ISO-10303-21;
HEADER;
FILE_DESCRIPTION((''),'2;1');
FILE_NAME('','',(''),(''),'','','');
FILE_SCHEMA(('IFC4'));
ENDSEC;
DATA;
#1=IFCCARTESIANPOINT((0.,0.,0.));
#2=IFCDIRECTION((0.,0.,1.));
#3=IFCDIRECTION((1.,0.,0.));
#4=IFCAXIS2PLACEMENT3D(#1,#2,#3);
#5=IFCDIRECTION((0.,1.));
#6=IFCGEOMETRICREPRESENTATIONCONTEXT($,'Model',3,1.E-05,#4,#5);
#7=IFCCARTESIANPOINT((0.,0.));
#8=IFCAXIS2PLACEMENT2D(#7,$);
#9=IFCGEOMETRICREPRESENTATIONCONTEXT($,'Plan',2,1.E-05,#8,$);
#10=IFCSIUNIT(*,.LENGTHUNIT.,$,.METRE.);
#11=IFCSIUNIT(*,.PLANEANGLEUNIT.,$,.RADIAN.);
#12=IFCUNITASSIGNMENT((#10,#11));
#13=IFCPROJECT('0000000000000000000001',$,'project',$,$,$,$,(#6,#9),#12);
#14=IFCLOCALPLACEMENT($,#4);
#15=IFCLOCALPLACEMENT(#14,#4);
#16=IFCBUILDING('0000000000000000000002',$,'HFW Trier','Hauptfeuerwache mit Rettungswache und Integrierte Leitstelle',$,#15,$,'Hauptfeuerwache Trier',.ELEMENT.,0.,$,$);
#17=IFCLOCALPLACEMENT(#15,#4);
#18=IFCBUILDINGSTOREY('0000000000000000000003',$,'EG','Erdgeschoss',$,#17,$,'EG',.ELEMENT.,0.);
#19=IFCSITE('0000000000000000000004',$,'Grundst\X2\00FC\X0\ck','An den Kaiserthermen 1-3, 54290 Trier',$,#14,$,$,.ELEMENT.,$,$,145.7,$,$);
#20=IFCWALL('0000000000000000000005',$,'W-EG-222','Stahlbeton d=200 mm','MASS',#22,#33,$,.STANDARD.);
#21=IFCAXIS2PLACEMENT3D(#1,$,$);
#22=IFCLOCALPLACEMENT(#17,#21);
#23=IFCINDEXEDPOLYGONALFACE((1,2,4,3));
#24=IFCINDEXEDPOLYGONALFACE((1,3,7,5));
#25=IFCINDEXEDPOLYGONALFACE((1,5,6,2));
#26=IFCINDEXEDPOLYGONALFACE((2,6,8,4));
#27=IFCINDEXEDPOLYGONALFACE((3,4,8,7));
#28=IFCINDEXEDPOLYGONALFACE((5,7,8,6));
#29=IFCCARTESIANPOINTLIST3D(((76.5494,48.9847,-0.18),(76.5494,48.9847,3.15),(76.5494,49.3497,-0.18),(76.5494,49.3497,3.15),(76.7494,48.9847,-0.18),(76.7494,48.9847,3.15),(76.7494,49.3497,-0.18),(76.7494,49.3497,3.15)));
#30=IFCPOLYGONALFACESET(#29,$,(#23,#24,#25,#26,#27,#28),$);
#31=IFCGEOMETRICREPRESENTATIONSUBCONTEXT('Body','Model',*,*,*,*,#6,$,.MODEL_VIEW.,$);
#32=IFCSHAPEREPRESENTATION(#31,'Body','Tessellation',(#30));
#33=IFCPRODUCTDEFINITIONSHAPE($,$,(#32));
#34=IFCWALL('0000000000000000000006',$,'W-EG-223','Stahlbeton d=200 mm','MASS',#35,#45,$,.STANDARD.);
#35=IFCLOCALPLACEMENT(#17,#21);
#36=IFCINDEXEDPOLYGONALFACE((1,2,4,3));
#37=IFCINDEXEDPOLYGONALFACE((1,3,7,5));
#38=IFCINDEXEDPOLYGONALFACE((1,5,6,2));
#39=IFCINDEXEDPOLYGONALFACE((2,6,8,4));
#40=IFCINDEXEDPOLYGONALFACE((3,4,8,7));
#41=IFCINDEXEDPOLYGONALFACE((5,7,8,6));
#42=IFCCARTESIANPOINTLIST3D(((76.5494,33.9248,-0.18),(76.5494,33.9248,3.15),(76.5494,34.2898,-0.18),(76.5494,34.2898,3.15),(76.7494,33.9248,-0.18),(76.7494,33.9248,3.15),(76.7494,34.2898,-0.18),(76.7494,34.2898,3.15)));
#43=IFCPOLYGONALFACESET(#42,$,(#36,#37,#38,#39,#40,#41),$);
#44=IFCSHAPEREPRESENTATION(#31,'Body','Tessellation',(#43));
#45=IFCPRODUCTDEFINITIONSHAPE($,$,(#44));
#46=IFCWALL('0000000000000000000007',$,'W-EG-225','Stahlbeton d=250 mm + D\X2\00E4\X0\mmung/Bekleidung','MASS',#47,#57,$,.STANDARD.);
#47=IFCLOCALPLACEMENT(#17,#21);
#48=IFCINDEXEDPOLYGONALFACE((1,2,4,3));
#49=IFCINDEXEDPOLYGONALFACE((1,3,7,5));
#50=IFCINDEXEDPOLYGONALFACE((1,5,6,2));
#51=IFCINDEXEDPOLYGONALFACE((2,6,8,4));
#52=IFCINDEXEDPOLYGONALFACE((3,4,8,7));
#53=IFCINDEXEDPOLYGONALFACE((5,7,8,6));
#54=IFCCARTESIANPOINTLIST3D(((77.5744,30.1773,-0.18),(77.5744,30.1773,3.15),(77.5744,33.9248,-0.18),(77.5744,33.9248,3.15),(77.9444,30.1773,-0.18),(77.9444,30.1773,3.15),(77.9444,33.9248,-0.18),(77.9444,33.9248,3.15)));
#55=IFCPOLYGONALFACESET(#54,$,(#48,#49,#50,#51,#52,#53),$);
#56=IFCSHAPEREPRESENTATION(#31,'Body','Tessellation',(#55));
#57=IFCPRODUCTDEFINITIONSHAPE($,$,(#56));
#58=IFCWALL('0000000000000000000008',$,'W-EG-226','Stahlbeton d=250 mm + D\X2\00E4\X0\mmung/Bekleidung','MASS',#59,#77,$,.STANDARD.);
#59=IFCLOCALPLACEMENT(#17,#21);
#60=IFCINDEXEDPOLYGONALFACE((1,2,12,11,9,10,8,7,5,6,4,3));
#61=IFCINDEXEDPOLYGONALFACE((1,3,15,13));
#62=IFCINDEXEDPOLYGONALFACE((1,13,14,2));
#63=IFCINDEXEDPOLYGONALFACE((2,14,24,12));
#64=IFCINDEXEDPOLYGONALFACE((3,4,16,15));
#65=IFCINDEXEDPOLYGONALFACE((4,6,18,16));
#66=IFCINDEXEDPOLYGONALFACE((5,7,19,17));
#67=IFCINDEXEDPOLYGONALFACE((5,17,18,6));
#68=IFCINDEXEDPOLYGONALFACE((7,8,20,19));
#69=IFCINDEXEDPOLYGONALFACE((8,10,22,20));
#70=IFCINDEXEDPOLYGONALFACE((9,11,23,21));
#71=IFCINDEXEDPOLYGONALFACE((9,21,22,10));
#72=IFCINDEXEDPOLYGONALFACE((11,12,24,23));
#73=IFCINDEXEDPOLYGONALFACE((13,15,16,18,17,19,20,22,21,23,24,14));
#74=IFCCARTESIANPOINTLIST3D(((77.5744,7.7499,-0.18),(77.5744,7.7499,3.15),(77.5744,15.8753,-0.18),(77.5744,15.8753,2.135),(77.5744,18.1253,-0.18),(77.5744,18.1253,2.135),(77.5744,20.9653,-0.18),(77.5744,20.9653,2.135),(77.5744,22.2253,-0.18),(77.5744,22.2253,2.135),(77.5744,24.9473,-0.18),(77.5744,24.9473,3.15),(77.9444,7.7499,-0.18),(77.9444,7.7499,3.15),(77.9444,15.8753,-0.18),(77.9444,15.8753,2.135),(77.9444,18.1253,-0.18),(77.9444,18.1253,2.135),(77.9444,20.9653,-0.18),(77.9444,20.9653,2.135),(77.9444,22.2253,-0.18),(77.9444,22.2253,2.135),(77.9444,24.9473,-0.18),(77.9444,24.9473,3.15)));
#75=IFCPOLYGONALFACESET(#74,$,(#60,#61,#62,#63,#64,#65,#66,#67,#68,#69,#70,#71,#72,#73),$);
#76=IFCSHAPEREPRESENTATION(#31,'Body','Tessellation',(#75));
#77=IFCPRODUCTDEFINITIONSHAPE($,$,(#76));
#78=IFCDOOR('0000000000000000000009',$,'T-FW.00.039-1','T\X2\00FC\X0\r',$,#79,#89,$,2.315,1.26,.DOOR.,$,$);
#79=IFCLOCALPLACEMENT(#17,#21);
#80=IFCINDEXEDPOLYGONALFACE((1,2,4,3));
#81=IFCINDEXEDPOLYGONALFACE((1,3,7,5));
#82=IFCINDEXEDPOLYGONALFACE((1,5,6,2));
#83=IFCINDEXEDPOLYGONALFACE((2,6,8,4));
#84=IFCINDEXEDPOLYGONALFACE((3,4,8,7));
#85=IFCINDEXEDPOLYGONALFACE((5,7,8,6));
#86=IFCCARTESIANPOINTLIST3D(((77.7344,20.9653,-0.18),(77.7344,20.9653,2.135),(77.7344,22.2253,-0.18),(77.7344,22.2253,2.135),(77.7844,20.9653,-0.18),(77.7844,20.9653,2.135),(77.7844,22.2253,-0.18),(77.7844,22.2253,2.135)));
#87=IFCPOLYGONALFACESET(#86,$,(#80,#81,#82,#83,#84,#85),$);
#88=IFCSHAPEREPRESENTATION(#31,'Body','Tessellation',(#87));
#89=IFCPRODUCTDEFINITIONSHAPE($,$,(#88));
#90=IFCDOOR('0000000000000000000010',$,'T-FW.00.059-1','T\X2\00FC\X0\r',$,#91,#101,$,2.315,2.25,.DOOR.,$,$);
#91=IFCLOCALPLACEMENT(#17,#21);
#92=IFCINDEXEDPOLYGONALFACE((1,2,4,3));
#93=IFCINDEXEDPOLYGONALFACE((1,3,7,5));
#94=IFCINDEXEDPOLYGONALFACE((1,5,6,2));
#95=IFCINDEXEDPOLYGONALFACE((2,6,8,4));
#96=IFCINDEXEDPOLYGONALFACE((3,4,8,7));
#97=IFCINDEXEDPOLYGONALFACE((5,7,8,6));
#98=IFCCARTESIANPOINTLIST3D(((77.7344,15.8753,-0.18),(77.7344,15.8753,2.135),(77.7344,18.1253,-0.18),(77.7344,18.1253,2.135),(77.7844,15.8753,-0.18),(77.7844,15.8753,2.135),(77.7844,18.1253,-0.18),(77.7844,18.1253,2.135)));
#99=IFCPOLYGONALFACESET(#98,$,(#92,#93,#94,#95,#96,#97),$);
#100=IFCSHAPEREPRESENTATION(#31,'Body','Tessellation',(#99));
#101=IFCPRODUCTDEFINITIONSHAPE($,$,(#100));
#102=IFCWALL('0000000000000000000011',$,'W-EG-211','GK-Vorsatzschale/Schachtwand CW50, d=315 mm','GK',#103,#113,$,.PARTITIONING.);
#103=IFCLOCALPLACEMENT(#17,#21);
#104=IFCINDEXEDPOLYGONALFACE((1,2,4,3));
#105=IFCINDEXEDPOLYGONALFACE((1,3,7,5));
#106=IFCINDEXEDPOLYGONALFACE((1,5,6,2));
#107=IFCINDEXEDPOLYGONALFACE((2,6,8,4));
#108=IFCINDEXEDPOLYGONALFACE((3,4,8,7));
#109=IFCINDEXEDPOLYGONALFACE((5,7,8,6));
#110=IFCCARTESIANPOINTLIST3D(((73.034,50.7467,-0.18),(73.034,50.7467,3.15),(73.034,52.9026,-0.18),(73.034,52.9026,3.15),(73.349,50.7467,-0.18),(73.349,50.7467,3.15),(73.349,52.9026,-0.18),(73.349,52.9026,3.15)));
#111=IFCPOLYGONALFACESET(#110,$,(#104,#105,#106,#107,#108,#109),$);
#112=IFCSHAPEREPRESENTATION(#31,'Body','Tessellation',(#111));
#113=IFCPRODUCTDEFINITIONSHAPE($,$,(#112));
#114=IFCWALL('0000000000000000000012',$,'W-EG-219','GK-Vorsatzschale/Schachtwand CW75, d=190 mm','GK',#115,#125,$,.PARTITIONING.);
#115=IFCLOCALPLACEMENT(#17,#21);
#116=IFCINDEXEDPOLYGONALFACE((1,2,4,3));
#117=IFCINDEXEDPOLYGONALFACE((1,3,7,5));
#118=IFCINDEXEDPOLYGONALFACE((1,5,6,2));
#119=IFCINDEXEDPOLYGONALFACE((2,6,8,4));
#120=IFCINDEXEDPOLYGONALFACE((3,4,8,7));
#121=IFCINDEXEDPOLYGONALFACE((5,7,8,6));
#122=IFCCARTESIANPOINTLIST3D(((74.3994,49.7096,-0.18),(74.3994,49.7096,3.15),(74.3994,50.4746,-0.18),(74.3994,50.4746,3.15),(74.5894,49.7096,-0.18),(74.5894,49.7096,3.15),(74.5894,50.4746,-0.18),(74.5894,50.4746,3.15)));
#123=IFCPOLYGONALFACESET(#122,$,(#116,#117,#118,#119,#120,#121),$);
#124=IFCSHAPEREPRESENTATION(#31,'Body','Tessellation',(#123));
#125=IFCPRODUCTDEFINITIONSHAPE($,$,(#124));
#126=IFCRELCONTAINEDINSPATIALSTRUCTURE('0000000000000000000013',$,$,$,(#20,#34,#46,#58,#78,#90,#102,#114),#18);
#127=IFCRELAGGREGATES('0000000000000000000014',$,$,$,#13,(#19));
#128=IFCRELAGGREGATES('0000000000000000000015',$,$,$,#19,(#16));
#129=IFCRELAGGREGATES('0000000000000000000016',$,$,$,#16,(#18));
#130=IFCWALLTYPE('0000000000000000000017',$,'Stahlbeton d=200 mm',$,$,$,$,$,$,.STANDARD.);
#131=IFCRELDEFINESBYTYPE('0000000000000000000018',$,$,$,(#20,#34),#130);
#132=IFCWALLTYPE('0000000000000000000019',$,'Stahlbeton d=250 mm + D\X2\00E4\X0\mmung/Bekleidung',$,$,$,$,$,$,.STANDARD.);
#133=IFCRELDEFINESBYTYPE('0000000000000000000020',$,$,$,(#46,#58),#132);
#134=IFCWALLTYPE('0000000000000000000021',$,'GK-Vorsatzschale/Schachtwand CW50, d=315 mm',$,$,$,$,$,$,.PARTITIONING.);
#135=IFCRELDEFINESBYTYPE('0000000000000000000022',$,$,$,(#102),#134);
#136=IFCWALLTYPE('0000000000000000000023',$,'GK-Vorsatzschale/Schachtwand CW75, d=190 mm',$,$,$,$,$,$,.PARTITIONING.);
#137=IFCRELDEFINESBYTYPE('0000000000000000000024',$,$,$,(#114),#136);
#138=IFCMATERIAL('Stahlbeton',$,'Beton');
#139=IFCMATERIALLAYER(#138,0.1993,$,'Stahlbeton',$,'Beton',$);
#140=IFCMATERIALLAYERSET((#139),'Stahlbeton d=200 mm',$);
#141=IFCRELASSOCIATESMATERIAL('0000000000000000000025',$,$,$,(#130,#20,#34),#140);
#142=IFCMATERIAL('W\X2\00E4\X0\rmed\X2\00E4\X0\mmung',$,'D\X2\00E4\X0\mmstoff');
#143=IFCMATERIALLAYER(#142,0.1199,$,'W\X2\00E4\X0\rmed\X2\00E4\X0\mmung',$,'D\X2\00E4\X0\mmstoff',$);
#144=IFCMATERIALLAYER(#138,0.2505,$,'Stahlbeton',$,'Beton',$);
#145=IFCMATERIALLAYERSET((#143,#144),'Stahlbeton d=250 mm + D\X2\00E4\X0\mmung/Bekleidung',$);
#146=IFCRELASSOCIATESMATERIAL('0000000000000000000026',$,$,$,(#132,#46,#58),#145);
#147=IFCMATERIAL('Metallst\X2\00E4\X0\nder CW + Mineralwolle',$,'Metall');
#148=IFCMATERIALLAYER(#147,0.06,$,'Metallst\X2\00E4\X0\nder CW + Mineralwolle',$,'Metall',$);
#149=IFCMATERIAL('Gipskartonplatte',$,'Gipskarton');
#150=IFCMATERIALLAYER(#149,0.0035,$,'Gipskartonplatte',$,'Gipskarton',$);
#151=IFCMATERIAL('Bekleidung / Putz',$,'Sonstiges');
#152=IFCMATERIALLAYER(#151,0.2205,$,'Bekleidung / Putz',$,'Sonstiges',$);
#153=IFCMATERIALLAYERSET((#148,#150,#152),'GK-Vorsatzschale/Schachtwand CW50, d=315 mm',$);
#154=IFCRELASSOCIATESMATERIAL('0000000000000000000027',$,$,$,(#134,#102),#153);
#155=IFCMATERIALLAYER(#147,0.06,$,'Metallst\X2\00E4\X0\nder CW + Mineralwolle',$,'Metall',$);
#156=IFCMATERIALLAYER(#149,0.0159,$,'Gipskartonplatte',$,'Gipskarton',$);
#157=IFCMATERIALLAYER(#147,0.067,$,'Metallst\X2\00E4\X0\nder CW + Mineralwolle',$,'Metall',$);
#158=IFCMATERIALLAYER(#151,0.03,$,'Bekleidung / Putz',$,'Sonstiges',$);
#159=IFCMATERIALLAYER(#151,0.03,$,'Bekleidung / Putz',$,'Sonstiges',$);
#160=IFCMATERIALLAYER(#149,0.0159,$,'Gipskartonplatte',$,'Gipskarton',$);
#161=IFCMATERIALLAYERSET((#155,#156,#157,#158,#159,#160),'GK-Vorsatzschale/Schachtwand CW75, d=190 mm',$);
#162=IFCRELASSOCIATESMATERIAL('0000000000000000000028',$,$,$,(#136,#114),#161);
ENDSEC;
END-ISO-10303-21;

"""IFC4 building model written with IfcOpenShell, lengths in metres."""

from ifc_helpers import new_model, si_unit, direction, frame, frame_2d, origin_with_axes, origin_2d, place, context, subcontext, project, spatial, rectangle, extrude, material, layer, layer_set, layer_usage, type_object, element, fill, save


model = new_model("IFC4")

# Units and contexts
model_context = context("Model", 3, precision=1e-05, world=origin_with_axes(), true_north=direction((0.0, 1.0)))
plan_context = context("Plan", 2, precision=1e-05, world=origin_2d())
body_context = subcontext(model_context, "Body", "Model", "MODEL_VIEW")
ifc_project = project(units=[si_unit("LENGTHUNIT", "METRE"), si_unit("PLANEANGLEUNIT", "RADIAN")], contexts=[model_context, plan_context])

# Site, building, storey
site_placement = place(None, origin_with_axes())
site = spatial("IfcSite", under=ifc_project, at=site_placement, Name="Grundstück", Description="An den Kaiserthermen 1-3, 54290 Trier", CompositionType="ELEMENT", RefElevation=145.7)
building_placement = place(site_placement, origin_with_axes())
building = spatial("IfcBuilding", under=site, at=building_placement, Name="HFW Trier", Description="Hauptfeuerwache mit Rettungswache und Integrierte Leitstelle", LongName="Hauptfeuerwache Trier", CompositionType="ELEMENT", ElevationOfRefHeight=0.0)
storey_placement = place(building_placement, origin_with_axes())
storey = spatial("IfcBuildingStorey", under=building, at=storey_placement, Name="EG", Description="Erdgeschoss", LongName="EG", CompositionType="ELEMENT", Elevation=0.0)

# Walls
ifc_material_1 = material(Name="Stahlbeton", Category="Beton")
ifc_material_2 = material(Name="Bekleidung / Putz", Category="Sonstiges")
ifc_material_3 = material(Name="Metallständer CW + Mineralwolle", Category="Metall")
ifc_material_4 = material(Name="Gipskartonplatte", Category="Gipskarton")
ifc_material_5 = material(Name="Wärmedämmung", Category="Dämmstoff")
ifc_layer_1 = layer(ifc_material_1, 0.1993, Name="Stahlbeton", Category="Beton")
ifc_layer_set_1 = layer_set([ifc_layer_1], Name="Stahlbeton d=200 mm")
ifc_layer_usage_1 = layer_usage(ifc_layer_set_1, "AXIS2", "POSITIVE", -0.1)
wall_type_1 = type_object("IfcWallType", Name="Stahlbeton d=200 mm", PredefinedType="STANDARD", material=ifc_layer_set_1)
wall_1_placement = place(storey_placement, frame((76.6494, 49.3497, -0.18), z_axis=(0.0, 0.0, 1.0), x_axis=(0.0, -1.0, 0.0)))
element("IfcWall", 1, at=wall_1_placement, inside=storey, type_object=wall_type_1, material=ifc_layer_usage_1, Name="W-EG-222", Description="Stahlbeton d=200 mm", ObjectType="MASS", PredefinedType="STANDARD", context=body_context, shape_type="SweptSolid", body=[
    extrude(rectangle(XDim=0.365, YDim=0.2, at=frame_2d((0.1825, 0.0))), origin_with_axes(), (0.0, 0.0, 1.0), 3.33),
])
ifc_layer_usage_2 = layer_usage(ifc_layer_set_1, "AXIS2", "POSITIVE", -0.1)
wall_2_placement = place(storey_placement, frame((76.6494, 34.2898, -0.18), z_axis=(0.0, 0.0, 1.0), x_axis=(0.0, -1.0, 0.0)))
element("IfcWall", 2, at=wall_2_placement, inside=storey, type_object=wall_type_1, material=ifc_layer_usage_2, Name="W-EG-223", Description="Stahlbeton d=200 mm", ObjectType="MASS", PredefinedType="STANDARD", context=body_context, shape_type="SweptSolid", body=[
    extrude(rectangle(XDim=0.365, YDim=0.2, at=frame_2d((0.1825, 0.0))), origin_with_axes(), (0.0, 0.0, 1.0), 3.33),
])
ifc_layer_2 = layer(ifc_material_5, 0.1199, Name="Wärmedämmung", Category="Dämmstoff")
ifc_layer_3 = layer(ifc_material_1, 0.2505, Name="Stahlbeton", Category="Beton")
ifc_layer_set_2 = layer_set([ifc_layer_2, ifc_layer_3], Name="Stahlbeton d=250 mm + Dämmung/Bekleidung")
ifc_layer_usage_3 = layer_usage(ifc_layer_set_2, "AXIS2", "POSITIVE", -0.185)
wall_type_2 = type_object("IfcWallType", Name="Stahlbeton d=250 mm + Dämmung/Bekleidung", PredefinedType="STANDARD", material=ifc_layer_set_2)
wall_3_placement = place(storey_placement, frame((77.7594, 33.9248, -0.18), z_axis=(0.0, 0.0, 1.0), x_axis=(0.0, -1.0, 0.0)))
element("IfcWall", 3, at=wall_3_placement, inside=storey, type_object=wall_type_2, material=ifc_layer_usage_3, Name="W-EG-225", Description="Stahlbeton d=250 mm + Dämmung/Bekleidung", ObjectType="MASS", PredefinedType="STANDARD", context=body_context, shape_type="SweptSolid", body=[
    extrude(rectangle(XDim=3.7475, YDim=0.37, at=frame_2d((1.8737, 0.0))), origin_with_axes(), (0.0, 0.0, 1.0), 3.33),
])

# Wall, openings, doors
ifc_layer_usage_4 = layer_usage(ifc_layer_set_2, "AXIS2", "POSITIVE", -0.185)
wall_4_placement = place(storey_placement, frame((77.7594, 24.9473, -0.18), z_axis=(0.0, 0.0, 1.0), x_axis=(0.0, -1.0, 0.0)))
wall_4 = element("IfcWall", 4, at=wall_4_placement, inside=storey, type_object=wall_type_2, material=ifc_layer_usage_4, Name="W-EG-226", Description="Stahlbeton d=250 mm + Dämmung/Bekleidung", ObjectType="MASS", PredefinedType="STANDARD", context=body_context, shape_type="SweptSolid", body=[
    extrude(rectangle(XDim=17.1974, YDim=0.37, at=frame_2d((8.5987, 0.0))), origin_with_axes(), (0.0, 0.0, 1.0), 3.33),
])
opening_1_placement = place(wall_4_placement, frame((2.722, 0.0, 0.0), z_axis=(0.0, 0.0, 1.0), x_axis=(1.0, 0.0, 0.0)))
opening_1 = element("IfcOpeningElement", 5, at=opening_1_placement, cuts=wall_4, PredefinedType="OPENING", context=body_context, shape_type="SweptSolid", body=[
    extrude(rectangle(XDim=1.26, YDim=0.47, at=frame_2d((0.63, 0.0))), origin_with_axes(), (0.0, 0.0, 1.0), 2.315),
])
opening_2_placement = place(wall_4_placement, frame((6.822, 0.0, 0.0), z_axis=(0.0, 0.0, 1.0), x_axis=(1.0, 0.0, 0.0)))
opening_2 = element("IfcOpeningElement", 6, at=opening_2_placement, cuts=wall_4, PredefinedType="OPENING", context=body_context, shape_type="SweptSolid", body=[
    extrude(rectangle(XDim=2.25, YDim=0.47, at=frame_2d((1.125, 0.0))), origin_with_axes(), (0.0, 0.0, 1.0), 2.315),
])
door_1_placement = place(wall_4_placement, frame((2.722, 0.0, 0.0), z_axis=(0.0, 0.0, 1.0), x_axis=(1.0, 0.0, 0.0)))
door_1 = element("IfcDoor", 7, at=door_1_placement, inside=storey, Name="T-FW.00.039-1", Description="Tür", OverallHeight=2.315, OverallWidth=1.26, PredefinedType="DOOR", context=body_context, shape_type="SweptSolid", body=[
    extrude(rectangle(XDim=1.26, YDim=0.05, at=frame_2d((0.63, 0.0))), origin_with_axes(), (0.0, 0.0, 1.0), 2.315),
])
fill(opening_1, door_1)
door_2_placement = place(wall_4_placement, frame((6.822, 0.0, 0.0), z_axis=(0.0, 0.0, 1.0), x_axis=(1.0, 0.0, 0.0)))
door_2 = element("IfcDoor", 8, at=door_2_placement, inside=storey, Name="T-FW.00.059-1", Description="Tür", OverallHeight=2.315, OverallWidth=2.25, PredefinedType="DOOR", context=body_context, shape_type="SweptSolid", body=[
    extrude(rectangle(XDim=2.25, YDim=0.05, at=frame_2d((1.125, 0.0))), origin_with_axes(), (0.0, 0.0, 1.0), 2.315),
])
fill(opening_2, door_2)

# Walls
ifc_layer_4 = layer(ifc_material_3, 0.06, Name="Metallständer CW + Mineralwolle", Category="Metall")
ifc_layer_5 = layer(ifc_material_4, 0.0035, Name="Gipskartonplatte", Category="Gipskarton")
ifc_layer_6 = layer(ifc_material_2, 0.2205, Name="Bekleidung / Putz", Category="Sonstiges")
ifc_layer_set_3 = layer_set([ifc_layer_4, ifc_layer_5, ifc_layer_6], Name="GK-Vorsatzschale/Schachtwand CW50, d=315 mm")
ifc_layer_usage_5 = layer_usage(ifc_layer_set_3, "AXIS2", "POSITIVE", -0.1575)
wall_type_3 = type_object("IfcWallType", Name="GK-Vorsatzschale/Schachtwand CW50, d=315 mm", PredefinedType="PARTITIONING", material=ifc_layer_set_3)
wall_5_placement = place(storey_placement, frame((73.1915, 52.9026, -0.18), z_axis=(0.0, 0.0, 1.0), x_axis=(0.0, -1.0, 0.0)))
element("IfcWall", 9, at=wall_5_placement, inside=storey, type_object=wall_type_3, material=ifc_layer_usage_5, Name="W-EG-211", Description="GK-Vorsatzschale/Schachtwand CW50, d=315 mm", ObjectType="GK", PredefinedType="PARTITIONING", context=body_context, shape_type="SweptSolid", body=[
    extrude(rectangle(XDim=2.1559, YDim=0.315, at=frame_2d((1.078, 0.0))), origin_with_axes(), (0.0, 0.0, 1.0), 3.33),
])
ifc_layer_7 = layer(ifc_material_3, 0.06, Name="Metallständer CW + Mineralwolle", Category="Metall")
ifc_layer_8 = layer(ifc_material_4, 0.0159, Name="Gipskartonplatte", Category="Gipskarton")
ifc_layer_9 = layer(ifc_material_3, 0.067, Name="Metallständer CW + Mineralwolle", Category="Metall")
ifc_layer_10 = layer(ifc_material_2, 0.03, Name="Bekleidung / Putz", Category="Sonstiges")
ifc_layer_11 = layer(ifc_material_2, 0.03, Name="Bekleidung / Putz", Category="Sonstiges")
ifc_layer_12 = layer(ifc_material_4, 0.0159, Name="Gipskartonplatte", Category="Gipskarton")
ifc_layer_set_4 = layer_set([ifc_layer_7, ifc_layer_8, ifc_layer_9, ifc_layer_10, ifc_layer_11, ifc_layer_12], Name="GK-Vorsatzschale/Schachtwand CW75, d=190 mm")
ifc_layer_usage_6 = layer_usage(ifc_layer_set_4, "AXIS2", "POSITIVE", -0.095)
wall_type_4 = type_object("IfcWallType", Name="GK-Vorsatzschale/Schachtwand CW75, d=190 mm", PredefinedType="PARTITIONING", material=ifc_layer_set_4)
wall_6_placement = place(storey_placement, frame((74.4944, 50.4746, -0.18), z_axis=(0.0, 0.0, 1.0), x_axis=(0.0, -1.0, 0.0)))
element("IfcWall", 10, at=wall_6_placement, inside=storey, type_object=wall_type_4, material=ifc_layer_usage_6, Name="W-EG-219", Description="GK-Vorsatzschale/Schachtwand CW75, d=190 mm", ObjectType="GK", PredefinedType="PARTITIONING", context=body_context, shape_type="SweptSolid", body=[
    extrude(rectangle(XDim=0.765, YDim=0.19, at=frame_2d((0.3825, 0.0))), origin_with_axes(), (0.0, 0.0, 1.0), 3.33),
])

save(model, "model.ifc")
